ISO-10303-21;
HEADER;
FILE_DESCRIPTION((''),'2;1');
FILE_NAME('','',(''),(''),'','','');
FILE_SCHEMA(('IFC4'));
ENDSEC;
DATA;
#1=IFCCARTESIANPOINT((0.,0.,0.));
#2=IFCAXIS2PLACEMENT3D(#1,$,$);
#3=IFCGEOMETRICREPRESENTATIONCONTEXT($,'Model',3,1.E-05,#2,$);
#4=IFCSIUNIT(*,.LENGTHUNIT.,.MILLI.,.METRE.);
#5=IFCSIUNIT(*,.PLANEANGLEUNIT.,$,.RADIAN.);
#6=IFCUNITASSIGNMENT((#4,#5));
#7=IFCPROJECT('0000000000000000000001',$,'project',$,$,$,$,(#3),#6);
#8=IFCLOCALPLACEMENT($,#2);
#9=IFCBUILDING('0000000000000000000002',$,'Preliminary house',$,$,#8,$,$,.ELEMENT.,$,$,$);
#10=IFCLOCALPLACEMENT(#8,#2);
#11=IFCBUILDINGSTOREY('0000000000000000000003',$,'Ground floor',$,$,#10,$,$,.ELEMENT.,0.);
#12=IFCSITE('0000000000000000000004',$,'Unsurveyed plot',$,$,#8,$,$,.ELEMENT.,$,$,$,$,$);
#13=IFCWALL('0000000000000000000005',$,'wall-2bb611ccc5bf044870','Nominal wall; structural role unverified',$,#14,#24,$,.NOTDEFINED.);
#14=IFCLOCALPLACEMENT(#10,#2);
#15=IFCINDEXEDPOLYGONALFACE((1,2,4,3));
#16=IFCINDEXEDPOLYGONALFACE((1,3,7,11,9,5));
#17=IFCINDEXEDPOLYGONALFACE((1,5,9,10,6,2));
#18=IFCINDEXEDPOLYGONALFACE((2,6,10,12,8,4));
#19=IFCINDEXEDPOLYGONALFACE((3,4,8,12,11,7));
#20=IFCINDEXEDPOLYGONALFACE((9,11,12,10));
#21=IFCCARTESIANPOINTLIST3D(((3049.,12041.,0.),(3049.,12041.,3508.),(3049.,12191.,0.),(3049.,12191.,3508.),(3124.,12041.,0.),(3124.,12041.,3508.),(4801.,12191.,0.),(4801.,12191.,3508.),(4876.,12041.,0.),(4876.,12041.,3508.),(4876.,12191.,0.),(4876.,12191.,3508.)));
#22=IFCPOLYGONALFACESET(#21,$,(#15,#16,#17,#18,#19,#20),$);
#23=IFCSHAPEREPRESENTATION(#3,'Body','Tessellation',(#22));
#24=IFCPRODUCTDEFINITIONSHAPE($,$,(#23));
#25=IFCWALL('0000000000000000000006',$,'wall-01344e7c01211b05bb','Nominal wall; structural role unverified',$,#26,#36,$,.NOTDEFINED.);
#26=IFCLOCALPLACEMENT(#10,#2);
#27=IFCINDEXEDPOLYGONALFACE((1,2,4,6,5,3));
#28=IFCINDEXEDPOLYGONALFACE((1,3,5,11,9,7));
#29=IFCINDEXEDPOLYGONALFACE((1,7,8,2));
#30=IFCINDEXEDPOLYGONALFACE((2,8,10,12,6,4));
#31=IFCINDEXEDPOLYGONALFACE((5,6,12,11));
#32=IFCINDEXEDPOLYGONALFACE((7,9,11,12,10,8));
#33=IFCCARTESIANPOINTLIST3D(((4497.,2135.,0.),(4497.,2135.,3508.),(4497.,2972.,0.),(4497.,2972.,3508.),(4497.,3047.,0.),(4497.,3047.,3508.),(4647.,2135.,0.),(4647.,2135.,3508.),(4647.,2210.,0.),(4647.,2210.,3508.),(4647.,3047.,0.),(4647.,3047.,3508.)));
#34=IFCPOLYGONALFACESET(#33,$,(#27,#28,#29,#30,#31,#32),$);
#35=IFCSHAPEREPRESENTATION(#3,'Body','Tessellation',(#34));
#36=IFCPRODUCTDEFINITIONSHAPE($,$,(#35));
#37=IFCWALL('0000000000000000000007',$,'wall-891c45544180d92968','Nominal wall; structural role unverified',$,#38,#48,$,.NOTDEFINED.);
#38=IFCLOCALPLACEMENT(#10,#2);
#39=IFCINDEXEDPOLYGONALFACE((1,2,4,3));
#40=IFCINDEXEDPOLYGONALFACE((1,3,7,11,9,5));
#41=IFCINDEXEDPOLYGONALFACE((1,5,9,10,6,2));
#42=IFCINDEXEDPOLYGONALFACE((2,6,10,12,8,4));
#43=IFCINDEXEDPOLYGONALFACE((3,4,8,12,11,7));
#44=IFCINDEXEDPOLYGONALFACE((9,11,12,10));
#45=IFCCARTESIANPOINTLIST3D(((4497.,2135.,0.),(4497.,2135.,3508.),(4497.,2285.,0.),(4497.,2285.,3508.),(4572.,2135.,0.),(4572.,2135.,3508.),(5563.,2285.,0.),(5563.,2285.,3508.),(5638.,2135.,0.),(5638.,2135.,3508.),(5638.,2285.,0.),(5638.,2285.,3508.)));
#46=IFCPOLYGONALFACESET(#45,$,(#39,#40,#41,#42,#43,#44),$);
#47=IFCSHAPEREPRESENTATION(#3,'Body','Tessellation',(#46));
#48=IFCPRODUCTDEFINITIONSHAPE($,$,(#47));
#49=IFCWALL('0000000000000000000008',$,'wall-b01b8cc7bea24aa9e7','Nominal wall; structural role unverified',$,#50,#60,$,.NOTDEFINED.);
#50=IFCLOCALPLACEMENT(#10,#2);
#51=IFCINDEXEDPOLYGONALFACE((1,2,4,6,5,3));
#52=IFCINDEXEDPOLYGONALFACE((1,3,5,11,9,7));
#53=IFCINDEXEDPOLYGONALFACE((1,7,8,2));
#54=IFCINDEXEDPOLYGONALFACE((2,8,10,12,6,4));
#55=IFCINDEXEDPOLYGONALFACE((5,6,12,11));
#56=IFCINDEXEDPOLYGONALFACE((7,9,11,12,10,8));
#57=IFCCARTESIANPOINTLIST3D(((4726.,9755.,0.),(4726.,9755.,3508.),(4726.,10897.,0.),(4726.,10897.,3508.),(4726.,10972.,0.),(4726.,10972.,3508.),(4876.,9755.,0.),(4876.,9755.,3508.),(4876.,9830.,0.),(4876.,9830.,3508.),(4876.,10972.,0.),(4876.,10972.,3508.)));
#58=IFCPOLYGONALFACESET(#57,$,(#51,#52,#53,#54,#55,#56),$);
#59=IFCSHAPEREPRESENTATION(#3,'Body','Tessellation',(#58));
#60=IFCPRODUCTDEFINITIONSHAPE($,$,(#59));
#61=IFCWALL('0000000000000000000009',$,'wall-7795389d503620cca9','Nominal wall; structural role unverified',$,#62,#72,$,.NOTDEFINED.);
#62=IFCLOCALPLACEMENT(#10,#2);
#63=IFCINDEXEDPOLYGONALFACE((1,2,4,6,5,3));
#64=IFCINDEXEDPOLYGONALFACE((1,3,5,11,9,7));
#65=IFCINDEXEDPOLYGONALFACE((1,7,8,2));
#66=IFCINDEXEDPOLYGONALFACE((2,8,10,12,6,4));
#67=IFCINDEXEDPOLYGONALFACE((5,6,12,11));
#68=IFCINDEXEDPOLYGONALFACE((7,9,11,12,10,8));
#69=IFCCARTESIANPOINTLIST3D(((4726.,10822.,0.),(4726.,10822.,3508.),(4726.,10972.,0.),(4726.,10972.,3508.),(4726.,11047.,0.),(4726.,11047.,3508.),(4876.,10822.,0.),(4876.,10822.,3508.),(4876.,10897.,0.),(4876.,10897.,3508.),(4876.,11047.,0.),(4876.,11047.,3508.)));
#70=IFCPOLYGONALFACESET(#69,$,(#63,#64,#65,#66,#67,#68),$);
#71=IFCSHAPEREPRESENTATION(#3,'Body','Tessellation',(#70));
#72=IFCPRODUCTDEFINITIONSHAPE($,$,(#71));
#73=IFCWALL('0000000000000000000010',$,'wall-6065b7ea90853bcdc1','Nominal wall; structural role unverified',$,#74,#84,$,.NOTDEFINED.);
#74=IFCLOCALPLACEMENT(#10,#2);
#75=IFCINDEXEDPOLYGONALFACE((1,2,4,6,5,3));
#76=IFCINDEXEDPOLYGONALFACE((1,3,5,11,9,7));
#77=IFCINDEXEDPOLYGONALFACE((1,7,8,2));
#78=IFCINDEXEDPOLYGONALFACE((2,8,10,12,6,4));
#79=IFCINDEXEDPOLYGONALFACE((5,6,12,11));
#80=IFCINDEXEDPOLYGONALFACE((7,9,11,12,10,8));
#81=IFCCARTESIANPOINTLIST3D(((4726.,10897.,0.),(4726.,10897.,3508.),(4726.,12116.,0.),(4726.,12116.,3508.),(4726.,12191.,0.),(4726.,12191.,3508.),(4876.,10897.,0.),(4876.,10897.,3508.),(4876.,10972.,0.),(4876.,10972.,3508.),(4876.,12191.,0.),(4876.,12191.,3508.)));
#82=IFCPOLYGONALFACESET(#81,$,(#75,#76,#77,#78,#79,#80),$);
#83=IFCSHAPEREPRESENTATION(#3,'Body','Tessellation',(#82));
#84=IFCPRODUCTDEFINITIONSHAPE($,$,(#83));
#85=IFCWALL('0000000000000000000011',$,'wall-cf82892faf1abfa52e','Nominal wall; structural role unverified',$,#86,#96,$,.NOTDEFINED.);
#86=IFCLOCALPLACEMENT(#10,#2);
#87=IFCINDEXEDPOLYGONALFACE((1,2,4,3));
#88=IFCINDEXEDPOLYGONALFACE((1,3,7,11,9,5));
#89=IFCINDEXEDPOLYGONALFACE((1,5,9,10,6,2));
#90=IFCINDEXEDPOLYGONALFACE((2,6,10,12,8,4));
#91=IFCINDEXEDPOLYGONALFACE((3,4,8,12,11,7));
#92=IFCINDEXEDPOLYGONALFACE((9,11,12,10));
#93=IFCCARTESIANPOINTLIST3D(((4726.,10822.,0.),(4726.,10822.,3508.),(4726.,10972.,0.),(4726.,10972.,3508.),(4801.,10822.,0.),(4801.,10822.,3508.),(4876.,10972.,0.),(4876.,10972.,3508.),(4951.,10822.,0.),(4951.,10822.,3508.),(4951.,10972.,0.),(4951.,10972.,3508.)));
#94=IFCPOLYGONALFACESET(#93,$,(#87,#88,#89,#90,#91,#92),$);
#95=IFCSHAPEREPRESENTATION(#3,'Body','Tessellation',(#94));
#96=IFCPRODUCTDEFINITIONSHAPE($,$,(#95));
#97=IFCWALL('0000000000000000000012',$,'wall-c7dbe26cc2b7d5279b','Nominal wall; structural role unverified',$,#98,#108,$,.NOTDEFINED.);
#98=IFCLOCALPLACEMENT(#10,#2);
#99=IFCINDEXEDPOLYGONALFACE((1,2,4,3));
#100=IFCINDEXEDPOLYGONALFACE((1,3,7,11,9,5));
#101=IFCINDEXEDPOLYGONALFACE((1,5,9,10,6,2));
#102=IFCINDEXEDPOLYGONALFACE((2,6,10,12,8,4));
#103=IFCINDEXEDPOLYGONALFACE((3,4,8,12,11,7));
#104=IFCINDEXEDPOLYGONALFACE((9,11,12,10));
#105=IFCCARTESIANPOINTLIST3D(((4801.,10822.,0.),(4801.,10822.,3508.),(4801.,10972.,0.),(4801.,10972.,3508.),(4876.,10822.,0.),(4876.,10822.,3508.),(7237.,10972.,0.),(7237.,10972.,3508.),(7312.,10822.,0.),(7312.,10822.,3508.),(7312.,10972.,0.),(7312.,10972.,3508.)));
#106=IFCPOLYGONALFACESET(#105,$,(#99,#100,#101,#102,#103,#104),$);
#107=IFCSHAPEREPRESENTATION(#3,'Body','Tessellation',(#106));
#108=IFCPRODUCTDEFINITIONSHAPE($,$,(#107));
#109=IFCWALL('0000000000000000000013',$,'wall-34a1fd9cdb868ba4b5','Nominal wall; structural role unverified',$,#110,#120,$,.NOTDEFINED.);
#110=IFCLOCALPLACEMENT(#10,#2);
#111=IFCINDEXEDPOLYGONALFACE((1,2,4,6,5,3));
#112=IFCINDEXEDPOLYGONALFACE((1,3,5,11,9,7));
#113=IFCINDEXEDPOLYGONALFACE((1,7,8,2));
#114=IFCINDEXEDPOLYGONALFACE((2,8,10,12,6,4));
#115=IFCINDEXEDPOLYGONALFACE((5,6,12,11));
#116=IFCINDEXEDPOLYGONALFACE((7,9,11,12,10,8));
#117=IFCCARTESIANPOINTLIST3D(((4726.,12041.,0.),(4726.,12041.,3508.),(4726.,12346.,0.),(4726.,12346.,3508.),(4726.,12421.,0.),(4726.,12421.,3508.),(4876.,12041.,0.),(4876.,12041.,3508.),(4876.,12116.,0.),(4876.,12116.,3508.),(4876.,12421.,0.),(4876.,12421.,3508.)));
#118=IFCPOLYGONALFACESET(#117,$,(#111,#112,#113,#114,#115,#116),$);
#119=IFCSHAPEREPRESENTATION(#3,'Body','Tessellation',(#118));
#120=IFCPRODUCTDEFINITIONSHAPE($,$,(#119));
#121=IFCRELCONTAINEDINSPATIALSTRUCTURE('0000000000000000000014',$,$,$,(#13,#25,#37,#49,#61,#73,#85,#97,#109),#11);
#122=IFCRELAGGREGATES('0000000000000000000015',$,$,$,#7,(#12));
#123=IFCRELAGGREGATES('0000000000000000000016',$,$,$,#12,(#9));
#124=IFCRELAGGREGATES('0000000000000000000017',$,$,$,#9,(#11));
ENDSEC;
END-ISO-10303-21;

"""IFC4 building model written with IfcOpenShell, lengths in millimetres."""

from ifc_helpers import new_model, si_unit, origin, place, context, project, spatial, polyline, outline, extrude, element, save


model = new_model("IFC4")

# Units and contexts
model_context = context("Model", 3, precision=1e-05, world=origin())
ifc_project = project(units=[si_unit("LENGTHUNIT", "METRE", prefix="MILLI"), si_unit("PLANEANGLEUNIT", "RADIAN")], contexts=[model_context])

# Site, building, storey
placement_1 = place(None, origin())
site = spatial("IfcSite", under=ifc_project, at=placement_1, Name="Unsurveyed plot", CompositionType="ELEMENT")
building = spatial("IfcBuilding", under=site, at=placement_1, Name="Preliminary house", CompositionType="ELEMENT")
placement_2 = place(placement_1, origin())
storey = spatial("IfcBuildingStorey", under=building, at=placement_2, Name="Ground floor", CompositionType="ELEMENT", Elevation=0.0)

# Wall
element("IfcWall", 1, at=placement_2, inside=storey, Name="wall-2bb611ccc5bf044870", Description="Nominal wall; structural role unverified", PredefinedType="NOTDEFINED", context=model_context, shape_type="SweptSolid", body=[
    extrude(outline(polyline([(4801.0, 12191.0), (4876.0, 12191.0), (4876.0, 12041.0), (3124.0, 12041.0), (3049.0, 12041.0), (3049.0, 12191.0), (4801.0, 12191.0)])), origin(), (0.0, 0.0, 1.0), 3508.0),
])

# Walls
element("IfcWall", 2, at=placement_2, inside=storey, Name="wall-01344e7c01211b05bb", Description="Nominal wall; structural role unverified", PredefinedType="NOTDEFINED", context=model_context, shape_type="SweptSolid", body=[
    extrude(outline(polyline([(4497.0, 2972.0), (4497.0, 3047.0), (4647.0, 3047.0), (4647.0, 2210.0), (4647.0, 2135.0), (4497.0, 2135.0), (4497.0, 2972.0)])), origin(), (0.0, 0.0, 1.0), 3508.0),
])
element("IfcWall", 3, at=placement_2, inside=storey, Name="wall-891c45544180d92968", Description="Nominal wall; structural role unverified", PredefinedType="NOTDEFINED", context=model_context, shape_type="SweptSolid", body=[
    extrude(outline(polyline([(5563.0, 2285.0), (5638.0, 2285.0), (5638.0, 2135.0), (4572.0, 2135.0), (4497.0, 2135.0), (4497.0, 2285.0), (5563.0, 2285.0)])), origin(), (0.0, 0.0, 1.0), 3508.0),
])
element("IfcWall", 4, at=placement_2, inside=storey, Name="wall-b01b8cc7bea24aa9e7", Description="Nominal wall; structural role unverified", PredefinedType="NOTDEFINED", context=model_context, shape_type="SweptSolid", body=[
    extrude(outline(polyline([(4726.0, 10897.0), (4726.0, 10972.0), (4876.0, 10972.0), (4876.0, 9830.0), (4876.0, 9755.0), (4726.0, 9755.0), (4726.0, 10897.0)])), origin(), (0.0, 0.0, 1.0), 3508.0),
])

# Walls
element("IfcWall", 5, at=placement_2, inside=storey, Name="wall-7795389d503620cca9", Description="Nominal wall; structural role unverified", PredefinedType="NOTDEFINED", context=model_context, shape_type="SweptSolid", body=[
    extrude(outline(polyline([(4726.0, 10972.0), (4726.0, 11047.0), (4876.0, 11047.0), (4876.0, 10897.0), (4876.0, 10822.0), (4726.0, 10822.0), (4726.0, 10972.0)])), origin(), (0.0, 0.0, 1.0), 3508.0),
])
element("IfcWall", 6, at=placement_2, inside=storey, Name="wall-6065b7ea90853bcdc1", Description="Nominal wall; structural role unverified", PredefinedType="NOTDEFINED", context=model_context, shape_type="SweptSolid", body=[
    extrude(outline(polyline([(4726.0, 12116.0), (4726.0, 12191.0), (4876.0, 12191.0), (4876.0, 10972.0), (4876.0, 10897.0), (4726.0, 10897.0), (4726.0, 12116.0)])), origin(), (0.0, 0.0, 1.0), 3508.0),
])
element("IfcWall", 7, at=placement_2, inside=storey, Name="wall-cf82892faf1abfa52e", Description="Nominal wall; structural role unverified", PredefinedType="NOTDEFINED", context=model_context, shape_type="SweptSolid", body=[
    extrude(outline(polyline([(4876.0, 10972.0), (4951.0, 10972.0), (4951.0, 10822.0), (4801.0, 10822.0), (4726.0, 10822.0), (4726.0, 10972.0), (4876.0, 10972.0)])), origin(), (0.0, 0.0, 1.0), 3508.0),
])
element("IfcWall", 8, at=placement_2, inside=storey, Name="wall-c7dbe26cc2b7d5279b", Description="Nominal wall; structural role unverified", PredefinedType="NOTDEFINED", context=model_context, shape_type="SweptSolid", body=[
    extrude(outline(polyline([(7237.0, 10972.0), (7312.0, 10972.0), (7312.0, 10822.0), (4876.0, 10822.0), (4801.0, 10822.0), (4801.0, 10972.0), (7237.0, 10972.0)])), origin(), (0.0, 0.0, 1.0), 3508.0),
])
element("IfcWall", 9, at=placement_2, inside=storey, Name="wall-34a1fd9cdb868ba4b5", Description="Nominal wall; structural role unverified", PredefinedType="NOTDEFINED", context=model_context, shape_type="SweptSolid", body=[
    extrude(outline(polyline([(4726.0, 12346.0), (4726.0, 12421.0), (4876.0, 12421.0), (4876.0, 12116.0), (4876.0, 12041.0), (4726.0, 12041.0), (4726.0, 12346.0)])), origin(), (0.0, 0.0, 1.0), 3508.0),
])

save(model, "model.ifc")
